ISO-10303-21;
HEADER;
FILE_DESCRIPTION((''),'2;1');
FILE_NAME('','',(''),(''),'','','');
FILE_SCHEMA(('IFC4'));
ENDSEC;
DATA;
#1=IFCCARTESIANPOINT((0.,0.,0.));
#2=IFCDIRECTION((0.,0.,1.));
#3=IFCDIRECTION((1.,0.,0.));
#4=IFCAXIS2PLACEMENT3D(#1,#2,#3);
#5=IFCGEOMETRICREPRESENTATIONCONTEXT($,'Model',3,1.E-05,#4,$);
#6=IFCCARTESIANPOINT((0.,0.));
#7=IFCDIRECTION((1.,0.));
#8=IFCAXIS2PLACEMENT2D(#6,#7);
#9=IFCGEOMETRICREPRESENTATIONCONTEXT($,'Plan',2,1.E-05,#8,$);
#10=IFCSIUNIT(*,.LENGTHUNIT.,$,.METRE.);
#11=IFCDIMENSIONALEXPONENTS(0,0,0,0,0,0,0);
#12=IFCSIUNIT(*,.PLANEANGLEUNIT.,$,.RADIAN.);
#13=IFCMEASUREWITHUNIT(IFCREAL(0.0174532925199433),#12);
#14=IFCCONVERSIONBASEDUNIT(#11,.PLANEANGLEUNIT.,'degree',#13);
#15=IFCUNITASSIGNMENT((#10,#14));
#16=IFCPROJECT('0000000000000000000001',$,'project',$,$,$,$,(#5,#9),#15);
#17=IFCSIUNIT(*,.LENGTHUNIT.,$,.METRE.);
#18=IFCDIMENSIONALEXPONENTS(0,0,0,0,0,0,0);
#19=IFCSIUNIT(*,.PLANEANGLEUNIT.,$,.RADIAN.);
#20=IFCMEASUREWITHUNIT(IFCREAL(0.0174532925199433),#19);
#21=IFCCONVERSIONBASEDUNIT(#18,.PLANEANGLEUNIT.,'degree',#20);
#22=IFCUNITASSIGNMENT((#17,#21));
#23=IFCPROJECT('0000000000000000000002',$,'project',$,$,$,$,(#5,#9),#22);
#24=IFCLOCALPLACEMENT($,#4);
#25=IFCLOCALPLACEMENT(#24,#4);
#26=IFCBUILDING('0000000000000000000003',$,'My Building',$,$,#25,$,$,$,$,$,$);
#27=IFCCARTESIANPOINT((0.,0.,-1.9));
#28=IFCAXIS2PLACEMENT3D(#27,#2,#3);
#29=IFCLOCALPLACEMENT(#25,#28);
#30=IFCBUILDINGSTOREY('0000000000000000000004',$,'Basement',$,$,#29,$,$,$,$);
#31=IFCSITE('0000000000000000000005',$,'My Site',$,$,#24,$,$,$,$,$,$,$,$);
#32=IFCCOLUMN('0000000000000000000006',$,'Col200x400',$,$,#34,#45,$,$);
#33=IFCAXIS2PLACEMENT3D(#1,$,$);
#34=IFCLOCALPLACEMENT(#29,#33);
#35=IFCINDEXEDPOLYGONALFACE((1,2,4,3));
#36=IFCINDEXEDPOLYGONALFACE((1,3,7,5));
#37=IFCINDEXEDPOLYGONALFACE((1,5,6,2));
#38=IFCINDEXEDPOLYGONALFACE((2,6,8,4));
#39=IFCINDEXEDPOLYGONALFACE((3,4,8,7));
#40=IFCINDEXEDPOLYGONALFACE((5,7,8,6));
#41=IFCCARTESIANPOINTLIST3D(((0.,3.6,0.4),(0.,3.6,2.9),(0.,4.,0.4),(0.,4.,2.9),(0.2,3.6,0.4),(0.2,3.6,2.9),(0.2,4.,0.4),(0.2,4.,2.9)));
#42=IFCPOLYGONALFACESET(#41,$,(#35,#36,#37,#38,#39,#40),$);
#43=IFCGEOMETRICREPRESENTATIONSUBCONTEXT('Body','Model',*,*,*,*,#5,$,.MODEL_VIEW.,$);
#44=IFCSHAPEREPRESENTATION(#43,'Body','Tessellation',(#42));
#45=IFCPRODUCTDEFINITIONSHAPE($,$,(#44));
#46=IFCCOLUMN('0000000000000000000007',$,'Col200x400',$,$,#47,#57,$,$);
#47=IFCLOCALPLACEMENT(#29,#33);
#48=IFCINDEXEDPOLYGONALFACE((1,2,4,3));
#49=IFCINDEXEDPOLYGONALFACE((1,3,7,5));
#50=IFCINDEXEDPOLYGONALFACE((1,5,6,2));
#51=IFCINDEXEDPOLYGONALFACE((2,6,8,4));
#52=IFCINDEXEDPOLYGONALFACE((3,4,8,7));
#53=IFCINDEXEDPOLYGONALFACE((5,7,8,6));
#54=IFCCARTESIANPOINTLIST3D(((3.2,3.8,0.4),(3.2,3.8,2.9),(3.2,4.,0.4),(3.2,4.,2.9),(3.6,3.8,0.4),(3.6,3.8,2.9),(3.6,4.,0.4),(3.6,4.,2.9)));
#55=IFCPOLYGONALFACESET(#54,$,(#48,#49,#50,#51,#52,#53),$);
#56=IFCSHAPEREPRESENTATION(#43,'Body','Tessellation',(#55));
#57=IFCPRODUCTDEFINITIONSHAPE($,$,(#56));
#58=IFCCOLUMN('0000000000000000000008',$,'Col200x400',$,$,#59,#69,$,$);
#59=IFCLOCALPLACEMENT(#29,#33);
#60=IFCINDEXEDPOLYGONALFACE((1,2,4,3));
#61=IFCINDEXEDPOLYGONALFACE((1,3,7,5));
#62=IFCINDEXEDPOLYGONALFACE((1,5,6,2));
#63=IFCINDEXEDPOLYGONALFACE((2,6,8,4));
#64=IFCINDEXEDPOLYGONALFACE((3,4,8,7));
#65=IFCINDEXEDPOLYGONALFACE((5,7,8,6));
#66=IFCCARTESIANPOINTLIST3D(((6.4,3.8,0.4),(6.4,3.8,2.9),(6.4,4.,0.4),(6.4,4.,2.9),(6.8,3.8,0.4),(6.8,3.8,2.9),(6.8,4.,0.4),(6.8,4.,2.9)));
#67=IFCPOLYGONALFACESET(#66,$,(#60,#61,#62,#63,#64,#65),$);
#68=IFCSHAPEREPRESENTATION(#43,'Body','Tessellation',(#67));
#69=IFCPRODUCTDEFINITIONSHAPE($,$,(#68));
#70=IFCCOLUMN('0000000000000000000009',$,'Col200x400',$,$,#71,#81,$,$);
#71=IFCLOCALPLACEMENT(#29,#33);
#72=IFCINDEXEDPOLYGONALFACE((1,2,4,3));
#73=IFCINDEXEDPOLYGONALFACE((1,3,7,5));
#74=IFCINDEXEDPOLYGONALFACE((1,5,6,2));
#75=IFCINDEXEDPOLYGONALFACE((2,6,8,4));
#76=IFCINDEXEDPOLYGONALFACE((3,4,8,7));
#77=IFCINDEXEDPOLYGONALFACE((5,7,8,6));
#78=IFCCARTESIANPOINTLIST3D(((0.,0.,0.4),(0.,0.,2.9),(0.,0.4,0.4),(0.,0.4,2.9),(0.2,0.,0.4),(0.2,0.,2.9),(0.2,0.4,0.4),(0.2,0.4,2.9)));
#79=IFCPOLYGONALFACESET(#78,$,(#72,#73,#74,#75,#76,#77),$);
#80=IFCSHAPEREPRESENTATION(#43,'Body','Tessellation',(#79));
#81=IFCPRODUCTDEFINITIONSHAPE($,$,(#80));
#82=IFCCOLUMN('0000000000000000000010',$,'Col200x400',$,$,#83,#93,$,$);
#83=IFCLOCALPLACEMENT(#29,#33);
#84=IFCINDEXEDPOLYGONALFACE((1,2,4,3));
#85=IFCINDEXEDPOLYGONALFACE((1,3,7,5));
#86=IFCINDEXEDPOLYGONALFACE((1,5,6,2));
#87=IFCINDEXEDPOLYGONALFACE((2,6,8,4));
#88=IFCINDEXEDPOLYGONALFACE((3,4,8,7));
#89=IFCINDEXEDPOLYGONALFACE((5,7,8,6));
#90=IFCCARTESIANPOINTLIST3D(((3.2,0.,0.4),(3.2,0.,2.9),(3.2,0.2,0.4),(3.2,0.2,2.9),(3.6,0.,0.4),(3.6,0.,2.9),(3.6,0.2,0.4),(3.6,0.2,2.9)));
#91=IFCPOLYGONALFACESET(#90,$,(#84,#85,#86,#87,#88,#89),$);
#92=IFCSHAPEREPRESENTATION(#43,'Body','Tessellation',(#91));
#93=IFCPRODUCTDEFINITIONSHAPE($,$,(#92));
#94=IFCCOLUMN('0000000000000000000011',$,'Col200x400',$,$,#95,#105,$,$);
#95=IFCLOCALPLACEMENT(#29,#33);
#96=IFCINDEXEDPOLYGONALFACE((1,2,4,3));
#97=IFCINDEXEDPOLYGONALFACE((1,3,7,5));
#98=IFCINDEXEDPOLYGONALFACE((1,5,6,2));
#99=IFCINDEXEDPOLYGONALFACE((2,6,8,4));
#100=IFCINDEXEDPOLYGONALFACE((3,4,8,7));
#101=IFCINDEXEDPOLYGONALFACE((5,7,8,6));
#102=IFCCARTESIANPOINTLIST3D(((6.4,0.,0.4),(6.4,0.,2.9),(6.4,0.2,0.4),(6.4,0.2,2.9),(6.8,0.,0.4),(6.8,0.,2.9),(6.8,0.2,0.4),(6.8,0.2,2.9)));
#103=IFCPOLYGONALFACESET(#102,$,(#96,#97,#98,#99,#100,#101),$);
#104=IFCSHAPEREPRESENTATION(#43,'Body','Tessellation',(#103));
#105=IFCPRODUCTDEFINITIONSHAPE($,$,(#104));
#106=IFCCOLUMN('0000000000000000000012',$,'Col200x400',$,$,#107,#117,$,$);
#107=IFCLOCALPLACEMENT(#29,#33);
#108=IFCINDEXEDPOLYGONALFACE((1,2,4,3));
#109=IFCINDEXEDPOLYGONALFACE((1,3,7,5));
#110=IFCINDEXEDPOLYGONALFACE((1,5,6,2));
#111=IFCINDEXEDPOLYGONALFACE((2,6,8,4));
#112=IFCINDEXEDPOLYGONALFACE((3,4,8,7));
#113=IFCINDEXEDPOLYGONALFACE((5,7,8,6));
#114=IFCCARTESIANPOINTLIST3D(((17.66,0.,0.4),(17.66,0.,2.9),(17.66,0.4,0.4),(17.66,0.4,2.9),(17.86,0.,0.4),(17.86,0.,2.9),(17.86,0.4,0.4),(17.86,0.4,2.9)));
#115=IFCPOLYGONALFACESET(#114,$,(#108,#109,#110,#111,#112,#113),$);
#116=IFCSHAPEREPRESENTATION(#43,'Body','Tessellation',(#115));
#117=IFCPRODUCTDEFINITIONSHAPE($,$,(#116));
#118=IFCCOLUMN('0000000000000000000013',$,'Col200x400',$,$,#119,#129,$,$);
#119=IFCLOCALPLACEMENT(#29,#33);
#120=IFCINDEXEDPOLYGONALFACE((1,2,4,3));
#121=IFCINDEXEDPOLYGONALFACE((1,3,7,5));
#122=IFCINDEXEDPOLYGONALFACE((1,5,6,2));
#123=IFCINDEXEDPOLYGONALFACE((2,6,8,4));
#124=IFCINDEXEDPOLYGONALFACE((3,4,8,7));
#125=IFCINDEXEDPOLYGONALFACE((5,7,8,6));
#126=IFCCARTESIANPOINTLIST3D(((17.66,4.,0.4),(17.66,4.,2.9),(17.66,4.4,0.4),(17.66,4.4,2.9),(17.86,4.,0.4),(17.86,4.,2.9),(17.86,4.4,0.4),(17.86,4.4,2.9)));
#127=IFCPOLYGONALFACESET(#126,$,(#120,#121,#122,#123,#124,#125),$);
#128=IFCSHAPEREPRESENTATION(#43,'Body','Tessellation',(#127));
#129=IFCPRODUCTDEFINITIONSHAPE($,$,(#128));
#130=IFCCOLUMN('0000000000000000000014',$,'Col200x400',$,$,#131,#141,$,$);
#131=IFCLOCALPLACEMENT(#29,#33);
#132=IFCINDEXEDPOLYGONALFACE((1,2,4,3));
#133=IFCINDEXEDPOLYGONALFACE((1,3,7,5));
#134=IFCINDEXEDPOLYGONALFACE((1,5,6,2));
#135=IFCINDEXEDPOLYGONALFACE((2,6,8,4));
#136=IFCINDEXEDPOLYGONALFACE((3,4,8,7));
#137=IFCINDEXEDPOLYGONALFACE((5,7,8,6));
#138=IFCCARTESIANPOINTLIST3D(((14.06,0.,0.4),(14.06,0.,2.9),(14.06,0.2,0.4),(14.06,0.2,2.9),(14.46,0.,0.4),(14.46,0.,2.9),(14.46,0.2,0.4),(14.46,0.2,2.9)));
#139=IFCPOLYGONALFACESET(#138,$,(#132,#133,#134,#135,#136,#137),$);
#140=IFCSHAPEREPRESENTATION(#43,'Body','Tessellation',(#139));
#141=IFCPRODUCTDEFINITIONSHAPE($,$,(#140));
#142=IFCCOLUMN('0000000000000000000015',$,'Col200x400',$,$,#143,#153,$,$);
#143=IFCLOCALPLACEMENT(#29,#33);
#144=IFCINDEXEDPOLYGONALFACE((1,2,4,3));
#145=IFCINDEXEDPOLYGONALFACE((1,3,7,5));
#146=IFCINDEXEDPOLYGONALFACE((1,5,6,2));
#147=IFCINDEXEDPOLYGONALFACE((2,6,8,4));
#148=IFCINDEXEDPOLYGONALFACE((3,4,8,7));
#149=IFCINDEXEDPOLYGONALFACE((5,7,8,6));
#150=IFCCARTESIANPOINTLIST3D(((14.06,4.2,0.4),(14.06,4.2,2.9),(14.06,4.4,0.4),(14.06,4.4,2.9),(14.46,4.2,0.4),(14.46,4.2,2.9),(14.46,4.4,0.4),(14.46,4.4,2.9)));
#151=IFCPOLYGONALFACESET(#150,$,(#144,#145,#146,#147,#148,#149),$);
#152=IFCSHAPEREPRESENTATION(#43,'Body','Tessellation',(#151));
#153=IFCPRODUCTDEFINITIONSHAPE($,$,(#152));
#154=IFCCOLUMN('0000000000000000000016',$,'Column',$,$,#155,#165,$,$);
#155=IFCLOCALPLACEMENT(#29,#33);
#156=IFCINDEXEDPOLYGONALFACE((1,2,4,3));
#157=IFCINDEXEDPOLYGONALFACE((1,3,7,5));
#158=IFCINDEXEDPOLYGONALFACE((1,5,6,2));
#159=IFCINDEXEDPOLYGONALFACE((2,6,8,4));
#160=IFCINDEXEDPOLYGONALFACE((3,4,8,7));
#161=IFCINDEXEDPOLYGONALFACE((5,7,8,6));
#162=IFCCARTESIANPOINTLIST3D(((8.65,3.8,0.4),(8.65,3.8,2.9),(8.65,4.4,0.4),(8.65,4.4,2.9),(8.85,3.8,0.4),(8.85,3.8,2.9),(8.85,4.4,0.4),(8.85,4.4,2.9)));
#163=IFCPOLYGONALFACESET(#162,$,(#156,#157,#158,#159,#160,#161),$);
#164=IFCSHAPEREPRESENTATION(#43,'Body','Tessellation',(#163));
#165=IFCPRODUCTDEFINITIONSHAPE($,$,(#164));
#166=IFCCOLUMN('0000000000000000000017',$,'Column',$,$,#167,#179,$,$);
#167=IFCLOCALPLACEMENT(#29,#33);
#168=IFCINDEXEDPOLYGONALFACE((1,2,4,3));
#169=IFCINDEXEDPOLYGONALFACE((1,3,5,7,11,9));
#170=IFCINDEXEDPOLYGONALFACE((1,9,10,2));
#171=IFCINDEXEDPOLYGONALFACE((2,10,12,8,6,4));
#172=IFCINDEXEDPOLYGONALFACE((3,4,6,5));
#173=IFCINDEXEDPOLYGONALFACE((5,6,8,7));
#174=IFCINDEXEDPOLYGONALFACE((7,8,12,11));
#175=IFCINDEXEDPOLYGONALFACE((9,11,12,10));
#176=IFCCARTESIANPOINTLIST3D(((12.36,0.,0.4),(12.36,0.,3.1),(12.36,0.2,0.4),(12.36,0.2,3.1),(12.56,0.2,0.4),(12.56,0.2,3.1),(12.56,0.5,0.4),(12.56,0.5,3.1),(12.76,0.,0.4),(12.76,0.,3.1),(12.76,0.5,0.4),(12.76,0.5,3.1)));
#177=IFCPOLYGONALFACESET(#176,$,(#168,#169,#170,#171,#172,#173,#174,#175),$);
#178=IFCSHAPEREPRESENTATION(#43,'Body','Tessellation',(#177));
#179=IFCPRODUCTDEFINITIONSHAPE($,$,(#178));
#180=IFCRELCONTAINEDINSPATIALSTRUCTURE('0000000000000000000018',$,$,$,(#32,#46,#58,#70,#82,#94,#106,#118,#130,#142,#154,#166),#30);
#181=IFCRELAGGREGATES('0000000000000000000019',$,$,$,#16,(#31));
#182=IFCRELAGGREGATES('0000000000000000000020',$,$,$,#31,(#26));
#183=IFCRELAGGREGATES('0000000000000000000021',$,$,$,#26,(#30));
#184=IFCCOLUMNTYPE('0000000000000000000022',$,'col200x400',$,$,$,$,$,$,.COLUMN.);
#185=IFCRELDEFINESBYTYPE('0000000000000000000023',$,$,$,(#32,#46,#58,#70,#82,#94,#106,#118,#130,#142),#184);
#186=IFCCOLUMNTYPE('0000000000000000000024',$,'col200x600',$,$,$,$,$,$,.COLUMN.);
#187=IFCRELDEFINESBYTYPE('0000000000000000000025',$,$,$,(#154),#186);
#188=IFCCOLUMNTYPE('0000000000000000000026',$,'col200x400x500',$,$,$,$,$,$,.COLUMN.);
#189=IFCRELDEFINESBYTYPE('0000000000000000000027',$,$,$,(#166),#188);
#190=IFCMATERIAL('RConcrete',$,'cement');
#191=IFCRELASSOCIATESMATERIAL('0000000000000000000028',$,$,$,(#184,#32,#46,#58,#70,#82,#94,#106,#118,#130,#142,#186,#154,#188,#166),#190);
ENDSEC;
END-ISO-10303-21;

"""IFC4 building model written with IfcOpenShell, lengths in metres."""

from ifc_helpers import new_model, entity, si_unit, converted_unit, frame, origin_with_axes, origin_2d_with_axis, place, context, subcontext, project, spatial, line, indexed_curve, rectangle, outline, extrude, material, material_profile, profile_set, profile_usage, type_object, element, save


model = new_model("IFC4")

# Units and contexts
model_context = context("Model", 3, precision=1e-05, world=origin_with_axes())
plan_context = context("Plan", 2, precision=1e-05, world=origin_2d_with_axis())
body_context = subcontext(model_context, "Body", "Model", "MODEL_VIEW")
ifc_project_1 = project(units=[si_unit("LENGTHUNIT", "METRE"), converted_unit("PLANEANGLEUNIT", "degree", entity("IfcReal", 0.0174532925199433), si_unit("PLANEANGLEUNIT", "RADIAN"), dimensions=[0, 0, 0, 0, 0, 0, 0])], contexts=[model_context, plan_context])
ifc_project_2 = project(units=[si_unit("LENGTHUNIT", "METRE"), converted_unit("PLANEANGLEUNIT", "degree", entity("IfcReal", 0.0174532925199433), si_unit("PLANEANGLEUNIT", "RADIAN"), dimensions=[0, 0, 0, 0, 0, 0, 0])], contexts=[model_context, plan_context])

# Site, building, storey
site_placement = place(None, origin_with_axes())
site = spatial("IfcSite", under=ifc_project_1, at=site_placement, Name="My Site")
building_placement = place(site_placement, origin_with_axes())
building = spatial("IfcBuilding", under=site, at=building_placement, Name="My Building")
storey_placement = place(building_placement, frame((0.0, 0.0, -1.9), z_axis=(0.0, 0.0, 1.0), x_axis=(1.0, 0.0, 0.0)))
storey = spatial("IfcBuildingStorey", under=building, at=storey_placement, Name="Basement")

# Columns
ifc_material_1 = material(Name="RConcrete", Category="cement")
ifc_material_profile_1 = material_profile(ifc_material_1, rectangle(XDim=0.2, YDim=0.4))
ifc_profile_set_1 = profile_set([ifc_material_profile_1], Name="RConcrete")
ifc_profile_usage_1 = profile_usage(ifc_profile_set_1, cardinal=7)
column_type_1 = type_object("IfcColumnType", Name="col200x400", PredefinedType="COLUMN", material=ifc_profile_set_1)
column_1_placement = place(storey_placement, frame((0.2, 4.0, 0.4), z_axis=(0.0, 0.0, 1.0), x_axis=(1.0, 0.0, 0.0)))
element("IfcColumn", 1, at=column_1_placement, inside=storey, type_object=column_type_1, material=ifc_profile_usage_1, Name="Col200x400", context=body_context, shape_type="SweptSolid", body=[
    extrude(rectangle(XDim=0.2, YDim=0.4), frame((-0.1, -0.2, 0.0), z_axis=(0.0, 0.0, 1.0), x_axis=(1.0, 0.0, 0.0)), (0.0, 0.0, 1.0), 2.5),
])
ifc_profile_usage_2 = profile_usage(ifc_profile_set_1, cardinal=7)
column_2_placement = place(storey_placement, frame((3.2, 4.0, 0.4), z_axis=(0.0, 0.0, 1.0), x_axis=(0.0, 1.0, 0.0)))
element("IfcColumn", 2, at=column_2_placement, inside=storey, type_object=column_type_1, material=ifc_profile_usage_2, Name="Col200x400", context=body_context, shape_type="SweptSolid", body=[
    extrude(rectangle(XDim=0.2, YDim=0.4), frame((-0.1, -0.2, 0.0), z_axis=(0.0, 0.0, 1.0), x_axis=(1.0, 0.0, 0.0)), (0.0, 0.0, 1.0), 2.5),
])
ifc_profile_usage_3 = profile_usage(ifc_profile_set_1, cardinal=7)
column_3_placement = place(storey_placement, frame((6.4, 4.0, 0.4), z_axis=(0.0, 0.0, 1.0), x_axis=(0.0, 1.0, 0.0)))
element("IfcColumn", 3, at=column_3_placement, inside=storey, type_object=column_type_1, material=ifc_profile_usage_3, Name="Col200x400", context=body_context, shape_type="SweptSolid", body=[
    extrude(rectangle(XDim=0.2, YDim=0.4), frame((-0.1, -0.2, 0.0), z_axis=(0.0, 0.0, 1.0), x_axis=(1.0, 0.0, 0.0)), (0.0, 0.0, 1.0), 2.5),
])
ifc_profile_usage_4 = profile_usage(ifc_profile_set_1, cardinal=7)
column_4_placement = place(storey_placement, frame((0.2, 0.4, 0.4), z_axis=(0.0, 0.0, 1.0), x_axis=(1.0, 0.0, 0.0)))
element("IfcColumn", 4, at=column_4_placement, inside=storey, type_object=column_type_1, material=ifc_profile_usage_4, Name="Col200x400", context=body_context, shape_type="SweptSolid", body=[
    extrude(rectangle(XDim=0.2, YDim=0.4), frame((-0.1, -0.2, 0.0), z_axis=(0.0, 0.0, 1.0), x_axis=(1.0, 0.0, 0.0)), (0.0, 0.0, 1.0), 2.5),
])
ifc_profile_usage_5 = profile_usage(ifc_profile_set_1, cardinal=7)
column_5_placement = place(storey_placement, frame((3.2, 0.2, 0.4), z_axis=(0.0, 0.0, 1.0), x_axis=(0.0, 1.0, 0.0)))
element("IfcColumn", 5, at=column_5_placement, inside=storey, type_object=column_type_1, material=ifc_profile_usage_5, Name="Col200x400", context=body_context, shape_type="SweptSolid", body=[
    extrude(rectangle(XDim=0.2, YDim=0.4), frame((-0.1, -0.2, 0.0), z_axis=(0.0, 0.0, 1.0), x_axis=(1.0, 0.0, 0.0)), (0.0, 0.0, 1.0), 2.5),
])
ifc_profile_usage_6 = profile_usage(ifc_profile_set_1, cardinal=7)
column_6_placement = place(storey_placement, frame((6.4, 0.2, 0.4), z_axis=(0.0, 0.0, 1.0), x_axis=(0.0, 1.0, 0.0)))
element("IfcColumn", 6, at=column_6_placement, inside=storey, type_object=column_type_1, material=ifc_profile_usage_6, Name="Col200x400", context=body_context, shape_type="SweptSolid", body=[
    extrude(rectangle(XDim=0.2, YDim=0.4), frame((-0.1, -0.2, 0.0), z_axis=(0.0, 0.0, 1.0), x_axis=(1.0, 0.0, 0.0)), (0.0, 0.0, 1.0), 2.5),
])
ifc_profile_usage_7 = profile_usage(ifc_profile_set_1, cardinal=7)
column_7_placement = place(storey_placement, frame((17.86, 0.4, 0.4), z_axis=(0.0, 0.0, 1.0), x_axis=(1.0, 0.0, 0.0)))
element("IfcColumn", 7, at=column_7_placement, inside=storey, type_object=column_type_1, material=ifc_profile_usage_7, Name="Col200x400", context=body_context, shape_type="SweptSolid", body=[
    extrude(rectangle(XDim=0.2, YDim=0.4), frame((-0.1, -0.2, 0.0), z_axis=(0.0, 0.0, 1.0), x_axis=(1.0, 0.0, 0.0)), (0.0, 0.0, 1.0), 2.5),
])
ifc_profile_usage_8 = profile_usage(ifc_profile_set_1, cardinal=7)
column_8_placement = place(storey_placement, frame((17.86, 4.4, 0.4), z_axis=(0.0, 0.0, 1.0), x_axis=(1.0, 0.0, 0.0)))
element("IfcColumn", 8, at=column_8_placement, inside=storey, type_object=column_type_1, material=ifc_profile_usage_8, Name="Col200x400", context=body_context, shape_type="SweptSolid", body=[
    extrude(rectangle(XDim=0.2, YDim=0.4), frame((-0.1, -0.2, 0.0), z_axis=(0.0, 0.0, 1.0), x_axis=(1.0, 0.0, 0.0)), (0.0, 0.0, 1.0), 2.5),
])
ifc_profile_usage_9 = profile_usage(ifc_profile_set_1, cardinal=7)
column_9_placement = place(storey_placement, frame((14.06, 0.2, 0.4), z_axis=(0.0, 0.0, 1.0), x_axis=(0.0, 1.0, 0.0)))
element("IfcColumn", 9, at=column_9_placement, inside=storey, type_object=column_type_1, material=ifc_profile_usage_9, Name="Col200x400", context=body_context, shape_type="SweptSolid", body=[
    extrude(rectangle(XDim=0.2, YDim=0.4), frame((-0.1, -0.2, 0.0), z_axis=(0.0, 0.0, 1.0), x_axis=(1.0, 0.0, 0.0)), (0.0, 0.0, 1.0), 2.5),
])
ifc_profile_usage_10 = profile_usage(ifc_profile_set_1, cardinal=7)
column_10_placement = place(storey_placement, frame((14.06, 4.4, 0.4), z_axis=(0.0, 0.0, 1.0), x_axis=(0.0, 1.0, 0.0)))
element("IfcColumn", 10, at=column_10_placement, inside=storey, type_object=column_type_1, material=ifc_profile_usage_10, Name="Col200x400", context=body_context, shape_type="SweptSolid", body=[
    extrude(rectangle(XDim=0.2, YDim=0.4), frame((-0.1, -0.2, 0.0), z_axis=(0.0, 0.0, 1.0), x_axis=(1.0, 0.0, 0.0)), (0.0, 0.0, 1.0), 2.5),
])
ifc_material_profile_2 = material_profile(ifc_material_1, rectangle(XDim=0.2, YDim=0.6))
ifc_profile_set_2 = profile_set([ifc_material_profile_2], Name="RConcrete")
ifc_profile_usage_11 = profile_usage(ifc_profile_set_2, cardinal=7)
column_type_2 = type_object("IfcColumnType", Name="col200x600", PredefinedType="COLUMN", material=ifc_profile_set_2)
column_11_placement = place(storey_placement, frame((8.85, 4.4, 0.4), z_axis=(0.0, 0.0, 1.0), x_axis=(1.0, 0.0, 0.0)))
element("IfcColumn", 11, at=column_11_placement, inside=storey, type_object=column_type_2, material=ifc_profile_usage_11, Name="Column", context=body_context, shape_type="SweptSolid", body=[
    extrude(rectangle(XDim=0.2, YDim=0.6), frame((-0.1, -0.3, 0.0), z_axis=(0.0, 0.0, 1.0), x_axis=(1.0, 0.0, 0.0)), (0.0, 0.0, 1.0), 2.5),
])
ifc_material_profile_3 = material_profile(ifc_material_1, outline(indexed_curve([(0.2, 0.4), (0.2, 0.2), (0.5, 0.2), (0.5, 0.0), (0.0, 0.0), (0.0, 0.4)], segments=[line(6, 5), line(5, 4), line(4, 3), line(3, 2), line(2, 1), line(1, 6)], self_intersect=False)))
ifc_profile_set_3 = profile_set([ifc_material_profile_3], Name="RConcrete")
ifc_profile_usage_12 = profile_usage(ifc_profile_set_3, cardinal=5)
column_type_3 = type_object("IfcColumnType", Name="col200x400x500", PredefinedType="COLUMN", material=ifc_profile_set_3)
column_12_placement = place(storey_placement, frame((12.76, 0.0, 0.4), z_axis=(0.0, 0.0, 1.0), x_axis=(0.000001, 1.0, 0.0)))
element("IfcColumn", 12, at=column_12_placement, inside=storey, type_object=column_type_3, material=ifc_profile_usage_12, Name="Column", context=body_context, shape_type="SweptSolid", body=[
    extrude(outline(indexed_curve([(0.2, 0.4), (0.2, 0.2), (0.5, 0.2), (0.5, 0.0), (0.0, 0.0), (0.0, 0.4)], segments=[line(6, 5), line(5, 4), line(4, 3), line(3, 2), line(2, 1), line(1, 6)], self_intersect=False)), origin_with_axes(), (0.0, 0.0, 1.0), 2.7),
])

save(model, "model.ifc")
